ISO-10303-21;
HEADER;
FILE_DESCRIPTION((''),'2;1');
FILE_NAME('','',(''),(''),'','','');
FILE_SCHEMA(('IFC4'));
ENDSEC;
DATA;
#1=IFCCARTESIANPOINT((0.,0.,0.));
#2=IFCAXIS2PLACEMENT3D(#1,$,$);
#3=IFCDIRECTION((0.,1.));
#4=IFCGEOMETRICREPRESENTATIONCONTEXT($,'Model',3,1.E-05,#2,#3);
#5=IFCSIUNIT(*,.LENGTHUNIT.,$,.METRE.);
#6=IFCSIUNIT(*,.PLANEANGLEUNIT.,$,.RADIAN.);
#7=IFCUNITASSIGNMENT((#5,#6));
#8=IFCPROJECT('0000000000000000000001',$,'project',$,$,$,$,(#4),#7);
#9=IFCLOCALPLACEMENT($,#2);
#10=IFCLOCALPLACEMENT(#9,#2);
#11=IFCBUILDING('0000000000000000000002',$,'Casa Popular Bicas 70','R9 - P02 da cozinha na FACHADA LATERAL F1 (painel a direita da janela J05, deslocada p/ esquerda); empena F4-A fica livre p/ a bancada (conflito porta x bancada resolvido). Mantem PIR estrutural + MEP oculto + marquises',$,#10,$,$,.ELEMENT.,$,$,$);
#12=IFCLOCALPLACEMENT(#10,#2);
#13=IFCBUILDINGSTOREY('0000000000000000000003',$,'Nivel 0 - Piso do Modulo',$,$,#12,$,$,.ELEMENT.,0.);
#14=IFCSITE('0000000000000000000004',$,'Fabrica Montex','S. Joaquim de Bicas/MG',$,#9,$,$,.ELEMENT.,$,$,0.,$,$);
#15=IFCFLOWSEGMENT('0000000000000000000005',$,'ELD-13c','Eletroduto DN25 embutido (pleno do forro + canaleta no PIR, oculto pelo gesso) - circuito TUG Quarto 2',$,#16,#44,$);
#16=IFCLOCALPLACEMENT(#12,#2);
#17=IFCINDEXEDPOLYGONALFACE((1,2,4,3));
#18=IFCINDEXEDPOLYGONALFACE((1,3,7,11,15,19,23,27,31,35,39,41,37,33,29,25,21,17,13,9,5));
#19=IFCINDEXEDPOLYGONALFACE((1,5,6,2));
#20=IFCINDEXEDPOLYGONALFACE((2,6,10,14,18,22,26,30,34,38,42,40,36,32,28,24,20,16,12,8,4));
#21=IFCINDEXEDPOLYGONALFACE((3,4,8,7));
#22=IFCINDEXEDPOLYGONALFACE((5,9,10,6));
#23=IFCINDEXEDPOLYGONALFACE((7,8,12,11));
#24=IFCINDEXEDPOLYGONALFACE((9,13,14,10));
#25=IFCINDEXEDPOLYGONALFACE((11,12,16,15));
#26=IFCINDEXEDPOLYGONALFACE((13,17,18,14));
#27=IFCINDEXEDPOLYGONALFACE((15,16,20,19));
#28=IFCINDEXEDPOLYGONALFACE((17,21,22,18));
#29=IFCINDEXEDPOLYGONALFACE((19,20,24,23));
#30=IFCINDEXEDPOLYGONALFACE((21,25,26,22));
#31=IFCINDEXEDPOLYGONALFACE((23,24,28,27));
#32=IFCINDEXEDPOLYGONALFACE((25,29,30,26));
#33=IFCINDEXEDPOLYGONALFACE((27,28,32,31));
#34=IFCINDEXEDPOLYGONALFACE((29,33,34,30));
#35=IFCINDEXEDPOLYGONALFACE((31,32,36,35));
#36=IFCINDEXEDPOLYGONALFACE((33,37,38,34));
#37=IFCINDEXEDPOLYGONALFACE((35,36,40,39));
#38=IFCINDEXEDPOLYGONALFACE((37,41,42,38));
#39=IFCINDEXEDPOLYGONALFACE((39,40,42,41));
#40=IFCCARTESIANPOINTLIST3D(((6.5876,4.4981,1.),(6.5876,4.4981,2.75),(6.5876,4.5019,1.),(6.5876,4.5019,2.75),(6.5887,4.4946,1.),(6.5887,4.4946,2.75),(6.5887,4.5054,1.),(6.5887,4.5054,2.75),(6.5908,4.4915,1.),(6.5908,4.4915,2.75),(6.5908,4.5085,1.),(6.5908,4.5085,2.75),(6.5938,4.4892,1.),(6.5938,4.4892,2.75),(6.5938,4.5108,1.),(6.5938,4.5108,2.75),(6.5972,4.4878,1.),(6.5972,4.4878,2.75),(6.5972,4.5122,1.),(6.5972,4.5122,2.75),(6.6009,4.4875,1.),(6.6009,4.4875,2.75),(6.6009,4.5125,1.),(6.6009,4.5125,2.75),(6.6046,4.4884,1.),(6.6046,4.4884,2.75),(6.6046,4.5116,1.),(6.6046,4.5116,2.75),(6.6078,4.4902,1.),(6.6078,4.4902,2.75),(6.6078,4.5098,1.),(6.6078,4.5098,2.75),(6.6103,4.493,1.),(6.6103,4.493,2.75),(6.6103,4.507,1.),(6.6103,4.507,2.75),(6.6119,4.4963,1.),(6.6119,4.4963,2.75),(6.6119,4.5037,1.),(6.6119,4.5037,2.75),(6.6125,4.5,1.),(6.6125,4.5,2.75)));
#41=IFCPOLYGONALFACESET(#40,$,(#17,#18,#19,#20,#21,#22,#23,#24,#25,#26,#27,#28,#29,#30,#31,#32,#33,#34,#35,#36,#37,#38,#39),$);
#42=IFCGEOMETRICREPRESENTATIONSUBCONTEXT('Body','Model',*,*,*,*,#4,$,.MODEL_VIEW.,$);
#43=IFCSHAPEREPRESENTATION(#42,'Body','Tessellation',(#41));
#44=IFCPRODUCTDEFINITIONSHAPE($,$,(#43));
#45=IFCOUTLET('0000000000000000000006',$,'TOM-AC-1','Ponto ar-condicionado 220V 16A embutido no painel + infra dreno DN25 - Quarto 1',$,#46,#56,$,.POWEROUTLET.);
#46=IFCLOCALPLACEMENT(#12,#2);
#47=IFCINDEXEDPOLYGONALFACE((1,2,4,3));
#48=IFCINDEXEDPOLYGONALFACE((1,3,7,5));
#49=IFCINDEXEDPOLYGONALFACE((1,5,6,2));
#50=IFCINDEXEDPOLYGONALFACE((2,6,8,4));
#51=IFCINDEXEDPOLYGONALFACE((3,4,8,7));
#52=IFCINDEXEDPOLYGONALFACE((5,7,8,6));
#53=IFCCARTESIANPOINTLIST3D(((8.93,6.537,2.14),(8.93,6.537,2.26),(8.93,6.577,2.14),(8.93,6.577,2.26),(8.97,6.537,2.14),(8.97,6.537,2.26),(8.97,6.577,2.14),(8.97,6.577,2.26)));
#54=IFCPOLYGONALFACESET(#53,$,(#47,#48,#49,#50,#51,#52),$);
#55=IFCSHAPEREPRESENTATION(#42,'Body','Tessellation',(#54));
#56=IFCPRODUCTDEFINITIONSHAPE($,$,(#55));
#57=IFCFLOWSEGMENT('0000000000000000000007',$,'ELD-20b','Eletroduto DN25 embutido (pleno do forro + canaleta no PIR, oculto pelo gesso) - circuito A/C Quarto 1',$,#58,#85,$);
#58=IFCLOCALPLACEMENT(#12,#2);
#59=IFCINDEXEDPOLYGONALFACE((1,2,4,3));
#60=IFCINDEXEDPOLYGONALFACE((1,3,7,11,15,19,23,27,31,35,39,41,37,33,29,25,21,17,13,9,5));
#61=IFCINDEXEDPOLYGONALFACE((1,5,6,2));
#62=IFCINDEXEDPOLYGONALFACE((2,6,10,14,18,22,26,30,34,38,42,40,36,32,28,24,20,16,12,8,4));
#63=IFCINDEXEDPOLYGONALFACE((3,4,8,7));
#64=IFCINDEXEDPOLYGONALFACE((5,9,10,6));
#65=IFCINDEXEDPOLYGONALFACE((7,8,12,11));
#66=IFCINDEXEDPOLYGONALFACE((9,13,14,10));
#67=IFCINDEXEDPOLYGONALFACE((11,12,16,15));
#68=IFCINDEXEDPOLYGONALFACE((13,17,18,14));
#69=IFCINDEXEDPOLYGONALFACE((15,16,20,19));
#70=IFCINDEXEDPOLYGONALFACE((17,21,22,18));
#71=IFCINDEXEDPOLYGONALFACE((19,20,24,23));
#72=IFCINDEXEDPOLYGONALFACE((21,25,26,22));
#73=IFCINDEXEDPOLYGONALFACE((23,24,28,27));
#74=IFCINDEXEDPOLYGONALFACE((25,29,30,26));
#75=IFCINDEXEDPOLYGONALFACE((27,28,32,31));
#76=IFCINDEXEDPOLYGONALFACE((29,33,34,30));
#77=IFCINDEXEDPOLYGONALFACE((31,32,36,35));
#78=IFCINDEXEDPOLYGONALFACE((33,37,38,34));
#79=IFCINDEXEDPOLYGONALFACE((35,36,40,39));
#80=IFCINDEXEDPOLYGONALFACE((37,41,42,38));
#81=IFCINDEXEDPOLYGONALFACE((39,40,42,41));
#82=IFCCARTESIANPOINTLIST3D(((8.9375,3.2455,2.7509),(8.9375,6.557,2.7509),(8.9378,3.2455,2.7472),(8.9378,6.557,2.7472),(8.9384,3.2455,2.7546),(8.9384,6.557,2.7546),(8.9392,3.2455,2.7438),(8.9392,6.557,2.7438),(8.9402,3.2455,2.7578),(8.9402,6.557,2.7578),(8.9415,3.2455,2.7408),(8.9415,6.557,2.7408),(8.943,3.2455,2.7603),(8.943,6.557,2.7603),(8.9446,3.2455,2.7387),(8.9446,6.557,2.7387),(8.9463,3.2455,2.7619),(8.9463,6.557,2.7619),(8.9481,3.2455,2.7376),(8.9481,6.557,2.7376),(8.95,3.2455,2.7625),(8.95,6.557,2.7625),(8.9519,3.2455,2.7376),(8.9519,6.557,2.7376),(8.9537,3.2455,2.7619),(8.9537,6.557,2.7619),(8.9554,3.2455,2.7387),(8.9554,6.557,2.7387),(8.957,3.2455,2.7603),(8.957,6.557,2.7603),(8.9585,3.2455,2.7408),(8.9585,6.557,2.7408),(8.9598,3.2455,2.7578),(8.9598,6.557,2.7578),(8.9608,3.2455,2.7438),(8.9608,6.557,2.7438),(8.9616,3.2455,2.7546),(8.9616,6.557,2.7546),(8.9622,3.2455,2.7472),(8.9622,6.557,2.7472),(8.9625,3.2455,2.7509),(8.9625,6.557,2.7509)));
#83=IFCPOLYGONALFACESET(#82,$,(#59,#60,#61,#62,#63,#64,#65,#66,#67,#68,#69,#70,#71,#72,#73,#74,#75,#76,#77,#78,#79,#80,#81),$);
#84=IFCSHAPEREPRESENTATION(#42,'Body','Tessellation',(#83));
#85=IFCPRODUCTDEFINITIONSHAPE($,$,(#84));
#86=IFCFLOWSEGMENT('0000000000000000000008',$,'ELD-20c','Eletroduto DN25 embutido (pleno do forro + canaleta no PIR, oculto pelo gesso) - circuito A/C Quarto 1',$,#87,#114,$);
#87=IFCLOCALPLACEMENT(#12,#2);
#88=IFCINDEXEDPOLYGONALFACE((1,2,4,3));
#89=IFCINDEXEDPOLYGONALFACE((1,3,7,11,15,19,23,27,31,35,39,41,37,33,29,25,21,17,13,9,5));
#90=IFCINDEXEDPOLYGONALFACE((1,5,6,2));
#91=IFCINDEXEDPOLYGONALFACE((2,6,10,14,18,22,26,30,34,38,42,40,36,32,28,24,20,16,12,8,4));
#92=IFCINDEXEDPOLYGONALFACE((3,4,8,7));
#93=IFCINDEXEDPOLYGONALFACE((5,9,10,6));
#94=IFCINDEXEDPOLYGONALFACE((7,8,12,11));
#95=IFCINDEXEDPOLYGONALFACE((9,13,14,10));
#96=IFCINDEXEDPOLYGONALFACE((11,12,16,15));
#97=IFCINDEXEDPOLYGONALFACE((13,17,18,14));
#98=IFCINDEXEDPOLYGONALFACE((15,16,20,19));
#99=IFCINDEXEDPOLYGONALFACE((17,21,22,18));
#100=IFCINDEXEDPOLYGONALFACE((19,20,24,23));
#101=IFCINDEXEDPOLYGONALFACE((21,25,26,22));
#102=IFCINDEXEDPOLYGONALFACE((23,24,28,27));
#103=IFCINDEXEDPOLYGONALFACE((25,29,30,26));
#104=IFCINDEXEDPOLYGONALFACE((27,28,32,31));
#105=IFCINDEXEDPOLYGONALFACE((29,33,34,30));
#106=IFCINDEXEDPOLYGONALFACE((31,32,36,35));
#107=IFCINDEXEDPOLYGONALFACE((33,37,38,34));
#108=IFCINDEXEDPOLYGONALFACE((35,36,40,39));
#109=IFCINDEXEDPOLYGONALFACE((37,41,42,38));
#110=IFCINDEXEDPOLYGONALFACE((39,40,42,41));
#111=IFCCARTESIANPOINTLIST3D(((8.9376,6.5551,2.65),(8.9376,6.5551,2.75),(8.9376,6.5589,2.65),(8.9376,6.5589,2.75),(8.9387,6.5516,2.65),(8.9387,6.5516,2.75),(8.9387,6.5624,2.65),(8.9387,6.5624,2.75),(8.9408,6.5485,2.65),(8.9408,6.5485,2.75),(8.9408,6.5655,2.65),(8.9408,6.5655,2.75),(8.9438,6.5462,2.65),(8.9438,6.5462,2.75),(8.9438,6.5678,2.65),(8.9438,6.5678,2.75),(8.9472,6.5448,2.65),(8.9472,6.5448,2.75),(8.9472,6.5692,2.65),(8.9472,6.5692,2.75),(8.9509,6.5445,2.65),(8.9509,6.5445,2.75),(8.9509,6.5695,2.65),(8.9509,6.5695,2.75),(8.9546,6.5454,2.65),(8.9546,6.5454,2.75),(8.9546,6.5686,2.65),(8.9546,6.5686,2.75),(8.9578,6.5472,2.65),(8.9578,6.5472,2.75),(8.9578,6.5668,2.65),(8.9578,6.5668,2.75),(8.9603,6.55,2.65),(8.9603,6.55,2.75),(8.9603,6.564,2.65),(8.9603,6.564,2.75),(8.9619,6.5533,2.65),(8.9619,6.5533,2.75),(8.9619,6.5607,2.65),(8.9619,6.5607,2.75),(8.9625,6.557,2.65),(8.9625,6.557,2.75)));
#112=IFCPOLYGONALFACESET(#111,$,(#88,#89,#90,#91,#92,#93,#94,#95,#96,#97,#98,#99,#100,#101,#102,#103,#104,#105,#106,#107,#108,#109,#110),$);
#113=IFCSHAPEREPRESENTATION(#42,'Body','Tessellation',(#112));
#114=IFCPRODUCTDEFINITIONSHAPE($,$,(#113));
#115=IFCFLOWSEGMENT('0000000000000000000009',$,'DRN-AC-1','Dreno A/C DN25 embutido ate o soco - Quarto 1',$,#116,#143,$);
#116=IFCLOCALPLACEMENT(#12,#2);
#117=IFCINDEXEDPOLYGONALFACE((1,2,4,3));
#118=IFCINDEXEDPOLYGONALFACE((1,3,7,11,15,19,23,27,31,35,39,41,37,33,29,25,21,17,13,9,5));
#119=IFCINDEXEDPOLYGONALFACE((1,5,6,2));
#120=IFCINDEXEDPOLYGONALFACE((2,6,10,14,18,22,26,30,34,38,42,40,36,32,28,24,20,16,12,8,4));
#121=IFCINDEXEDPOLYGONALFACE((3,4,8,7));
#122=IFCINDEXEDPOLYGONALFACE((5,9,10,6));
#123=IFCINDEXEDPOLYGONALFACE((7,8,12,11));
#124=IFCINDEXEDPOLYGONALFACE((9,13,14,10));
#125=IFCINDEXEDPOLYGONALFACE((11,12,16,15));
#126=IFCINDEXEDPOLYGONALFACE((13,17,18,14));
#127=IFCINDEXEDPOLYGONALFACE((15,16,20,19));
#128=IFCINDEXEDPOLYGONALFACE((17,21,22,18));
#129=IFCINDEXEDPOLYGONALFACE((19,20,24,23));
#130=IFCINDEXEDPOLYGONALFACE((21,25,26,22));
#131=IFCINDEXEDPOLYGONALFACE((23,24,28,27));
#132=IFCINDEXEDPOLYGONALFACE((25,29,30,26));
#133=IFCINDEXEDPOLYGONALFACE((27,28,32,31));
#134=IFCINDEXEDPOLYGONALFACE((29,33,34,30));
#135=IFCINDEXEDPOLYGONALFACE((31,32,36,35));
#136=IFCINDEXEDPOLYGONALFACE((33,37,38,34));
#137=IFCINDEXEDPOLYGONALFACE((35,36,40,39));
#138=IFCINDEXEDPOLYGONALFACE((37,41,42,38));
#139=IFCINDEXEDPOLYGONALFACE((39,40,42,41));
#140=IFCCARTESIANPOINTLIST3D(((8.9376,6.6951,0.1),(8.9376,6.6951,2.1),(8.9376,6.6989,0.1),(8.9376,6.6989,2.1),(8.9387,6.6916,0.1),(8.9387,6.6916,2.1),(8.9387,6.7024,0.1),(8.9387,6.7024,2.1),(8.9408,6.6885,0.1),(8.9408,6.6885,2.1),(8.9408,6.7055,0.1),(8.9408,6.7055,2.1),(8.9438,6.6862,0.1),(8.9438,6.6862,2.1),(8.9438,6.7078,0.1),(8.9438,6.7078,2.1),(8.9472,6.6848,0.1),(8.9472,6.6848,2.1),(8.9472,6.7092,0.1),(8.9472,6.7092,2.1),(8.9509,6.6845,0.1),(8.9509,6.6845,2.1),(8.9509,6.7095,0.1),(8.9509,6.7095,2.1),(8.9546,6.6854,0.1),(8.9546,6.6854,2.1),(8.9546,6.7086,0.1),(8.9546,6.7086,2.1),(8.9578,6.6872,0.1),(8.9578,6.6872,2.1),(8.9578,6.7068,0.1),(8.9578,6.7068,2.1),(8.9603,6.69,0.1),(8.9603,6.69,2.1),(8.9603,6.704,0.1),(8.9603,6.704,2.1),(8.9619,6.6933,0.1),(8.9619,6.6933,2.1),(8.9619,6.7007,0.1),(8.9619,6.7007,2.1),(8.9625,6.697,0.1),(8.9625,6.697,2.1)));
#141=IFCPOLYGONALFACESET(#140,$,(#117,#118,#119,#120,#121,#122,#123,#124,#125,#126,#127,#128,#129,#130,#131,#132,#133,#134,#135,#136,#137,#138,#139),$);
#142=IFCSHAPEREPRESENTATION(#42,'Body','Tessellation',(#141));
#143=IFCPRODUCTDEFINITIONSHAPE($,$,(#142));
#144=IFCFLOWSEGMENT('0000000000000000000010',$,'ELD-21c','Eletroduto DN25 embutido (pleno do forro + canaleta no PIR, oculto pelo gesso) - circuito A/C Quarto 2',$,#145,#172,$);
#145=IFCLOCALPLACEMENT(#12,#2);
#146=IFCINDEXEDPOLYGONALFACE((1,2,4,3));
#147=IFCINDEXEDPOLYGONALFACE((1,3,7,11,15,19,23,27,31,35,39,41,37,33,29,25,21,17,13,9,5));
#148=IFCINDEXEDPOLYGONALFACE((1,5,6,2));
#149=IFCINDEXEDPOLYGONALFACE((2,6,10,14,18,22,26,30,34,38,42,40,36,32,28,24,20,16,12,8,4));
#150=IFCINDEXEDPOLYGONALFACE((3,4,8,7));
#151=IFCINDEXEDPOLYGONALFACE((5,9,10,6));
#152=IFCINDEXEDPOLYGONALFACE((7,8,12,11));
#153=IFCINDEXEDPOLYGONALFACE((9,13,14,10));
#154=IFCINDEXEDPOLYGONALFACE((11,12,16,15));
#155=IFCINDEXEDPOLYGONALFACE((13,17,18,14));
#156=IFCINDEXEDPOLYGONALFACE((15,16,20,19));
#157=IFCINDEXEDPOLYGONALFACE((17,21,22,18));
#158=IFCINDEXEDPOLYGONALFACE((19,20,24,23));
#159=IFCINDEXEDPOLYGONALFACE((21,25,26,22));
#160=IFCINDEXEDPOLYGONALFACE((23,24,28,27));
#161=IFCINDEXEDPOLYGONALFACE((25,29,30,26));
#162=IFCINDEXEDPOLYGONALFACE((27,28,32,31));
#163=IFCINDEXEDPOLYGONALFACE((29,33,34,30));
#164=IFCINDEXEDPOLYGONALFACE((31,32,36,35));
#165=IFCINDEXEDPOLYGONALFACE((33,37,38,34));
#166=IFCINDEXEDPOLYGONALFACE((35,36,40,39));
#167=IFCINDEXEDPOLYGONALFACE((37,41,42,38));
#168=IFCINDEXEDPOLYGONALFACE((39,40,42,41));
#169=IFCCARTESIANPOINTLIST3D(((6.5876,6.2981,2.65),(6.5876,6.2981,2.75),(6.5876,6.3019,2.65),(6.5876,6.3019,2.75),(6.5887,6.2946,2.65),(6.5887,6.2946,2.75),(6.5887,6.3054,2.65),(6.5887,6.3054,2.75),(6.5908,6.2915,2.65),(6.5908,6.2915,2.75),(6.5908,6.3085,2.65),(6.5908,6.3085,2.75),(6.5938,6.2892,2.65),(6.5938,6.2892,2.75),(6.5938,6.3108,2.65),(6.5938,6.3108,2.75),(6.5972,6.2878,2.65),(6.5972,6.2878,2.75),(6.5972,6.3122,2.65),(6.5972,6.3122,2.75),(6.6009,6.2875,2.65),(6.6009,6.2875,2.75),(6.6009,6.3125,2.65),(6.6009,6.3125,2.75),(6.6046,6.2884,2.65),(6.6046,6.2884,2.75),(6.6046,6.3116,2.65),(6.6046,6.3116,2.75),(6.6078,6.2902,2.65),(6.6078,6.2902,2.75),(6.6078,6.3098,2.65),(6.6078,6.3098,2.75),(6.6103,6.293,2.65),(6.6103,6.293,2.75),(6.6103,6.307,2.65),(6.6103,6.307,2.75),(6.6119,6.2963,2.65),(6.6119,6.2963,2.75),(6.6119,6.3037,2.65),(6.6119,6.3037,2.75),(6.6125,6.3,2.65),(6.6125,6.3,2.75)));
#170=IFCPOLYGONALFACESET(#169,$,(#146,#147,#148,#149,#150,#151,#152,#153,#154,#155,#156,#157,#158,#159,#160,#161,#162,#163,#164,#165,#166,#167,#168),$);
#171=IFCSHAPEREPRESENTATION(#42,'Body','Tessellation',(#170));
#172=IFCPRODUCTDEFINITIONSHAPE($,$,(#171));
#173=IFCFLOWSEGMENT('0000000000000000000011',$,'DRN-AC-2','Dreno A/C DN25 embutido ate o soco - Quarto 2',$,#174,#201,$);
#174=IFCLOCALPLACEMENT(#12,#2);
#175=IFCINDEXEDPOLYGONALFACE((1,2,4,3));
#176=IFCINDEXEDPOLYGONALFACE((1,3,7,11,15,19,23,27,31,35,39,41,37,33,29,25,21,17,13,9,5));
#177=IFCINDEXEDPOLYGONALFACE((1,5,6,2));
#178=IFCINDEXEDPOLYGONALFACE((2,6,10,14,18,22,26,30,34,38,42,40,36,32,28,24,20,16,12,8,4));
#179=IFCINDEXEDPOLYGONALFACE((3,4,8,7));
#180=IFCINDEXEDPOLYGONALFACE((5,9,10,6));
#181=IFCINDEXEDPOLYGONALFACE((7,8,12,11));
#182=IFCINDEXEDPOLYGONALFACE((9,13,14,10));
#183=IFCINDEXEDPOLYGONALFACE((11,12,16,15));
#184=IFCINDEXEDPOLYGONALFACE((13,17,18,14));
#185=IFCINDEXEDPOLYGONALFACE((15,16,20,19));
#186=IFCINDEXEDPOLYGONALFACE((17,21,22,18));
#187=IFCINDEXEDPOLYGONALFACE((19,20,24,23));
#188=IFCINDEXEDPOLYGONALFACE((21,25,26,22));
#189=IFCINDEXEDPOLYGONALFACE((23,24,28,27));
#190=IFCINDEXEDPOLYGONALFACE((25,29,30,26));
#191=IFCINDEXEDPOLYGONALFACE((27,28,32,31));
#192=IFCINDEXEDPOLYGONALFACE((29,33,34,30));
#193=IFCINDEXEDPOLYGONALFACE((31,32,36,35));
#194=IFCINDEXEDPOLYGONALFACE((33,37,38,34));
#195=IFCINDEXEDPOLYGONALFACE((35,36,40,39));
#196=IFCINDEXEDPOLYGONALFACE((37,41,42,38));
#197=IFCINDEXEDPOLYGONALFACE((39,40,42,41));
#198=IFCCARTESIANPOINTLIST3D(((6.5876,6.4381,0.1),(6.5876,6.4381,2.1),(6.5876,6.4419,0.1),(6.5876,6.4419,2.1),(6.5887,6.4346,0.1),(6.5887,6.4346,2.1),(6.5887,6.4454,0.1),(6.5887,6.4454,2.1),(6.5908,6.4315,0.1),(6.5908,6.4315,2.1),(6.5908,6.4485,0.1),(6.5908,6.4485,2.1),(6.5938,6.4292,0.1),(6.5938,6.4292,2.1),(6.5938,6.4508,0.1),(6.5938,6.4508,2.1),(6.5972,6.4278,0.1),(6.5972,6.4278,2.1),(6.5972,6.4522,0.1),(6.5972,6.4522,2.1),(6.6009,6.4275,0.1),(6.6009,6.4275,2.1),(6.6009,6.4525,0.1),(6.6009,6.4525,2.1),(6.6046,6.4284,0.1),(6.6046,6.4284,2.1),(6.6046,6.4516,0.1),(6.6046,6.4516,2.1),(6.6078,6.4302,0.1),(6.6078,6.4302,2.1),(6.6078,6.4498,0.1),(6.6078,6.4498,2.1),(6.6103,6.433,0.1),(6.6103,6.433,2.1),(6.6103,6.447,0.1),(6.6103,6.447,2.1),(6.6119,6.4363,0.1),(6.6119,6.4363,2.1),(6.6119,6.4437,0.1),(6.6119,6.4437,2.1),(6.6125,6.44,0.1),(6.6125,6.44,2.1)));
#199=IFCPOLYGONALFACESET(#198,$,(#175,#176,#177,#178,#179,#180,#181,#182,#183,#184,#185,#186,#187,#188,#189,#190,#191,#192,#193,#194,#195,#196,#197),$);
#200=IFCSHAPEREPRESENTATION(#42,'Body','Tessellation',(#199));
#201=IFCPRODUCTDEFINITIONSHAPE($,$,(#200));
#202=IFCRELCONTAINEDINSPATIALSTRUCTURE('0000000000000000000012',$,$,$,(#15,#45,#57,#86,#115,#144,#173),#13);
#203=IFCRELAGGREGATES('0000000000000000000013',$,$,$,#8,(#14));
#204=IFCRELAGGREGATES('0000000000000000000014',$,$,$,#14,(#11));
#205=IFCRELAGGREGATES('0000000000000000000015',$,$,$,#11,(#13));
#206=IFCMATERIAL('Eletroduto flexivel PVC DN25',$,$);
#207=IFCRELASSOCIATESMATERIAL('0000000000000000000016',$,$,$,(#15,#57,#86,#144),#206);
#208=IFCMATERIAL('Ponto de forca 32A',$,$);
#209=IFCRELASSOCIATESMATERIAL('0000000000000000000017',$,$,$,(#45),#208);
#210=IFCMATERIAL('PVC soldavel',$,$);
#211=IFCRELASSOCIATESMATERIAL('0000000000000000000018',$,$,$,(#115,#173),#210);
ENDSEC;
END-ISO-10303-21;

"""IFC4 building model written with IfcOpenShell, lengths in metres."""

from ifc_helpers import new_model, si_unit, direction, frame, frame_2d, origin, origin_2d, place, context, subcontext, project, spatial, rectangle, circle, extrude, material, element, save


model = new_model("IFC4")

# Units and contexts
model_context = context("Model", 3, precision=1e-05, world=origin(), true_north=direction((0.0, 1.0)))
body_context = subcontext(model_context, "Body", "Model", "MODEL_VIEW")
ifc_project = project(units=[si_unit("LENGTHUNIT", "METRE"), si_unit("PLANEANGLEUNIT", "RADIAN")], contexts=[model_context])

# Site, building, storey
site_placement = place(None, origin())
site = spatial("IfcSite", under=ifc_project, at=site_placement, Name="Fabrica Montex", Description="S. Joaquim de Bicas/MG", CompositionType="ELEMENT", RefElevation=0.0)
building_placement = place(site_placement, origin())
building = spatial("IfcBuilding", under=site, at=building_placement, Name="Casa Popular Bicas 70", Description="R9 - P02 da cozinha na FACHADA LATERAL F1 (painel a direita da janela J05, deslocada p/ esquerda); empena F4-A fica livre p/ a bancada (conflito porta x bancada resolvido). Mantem PIR estrutural + MEP oculto + marquises", CompositionType="ELEMENT")
storey_placement = place(building_placement, origin())
storey = spatial("IfcBuildingStorey", under=building, at=storey_placement, Name="Nivel 0 - Piso do Modulo", CompositionType="ELEMENT", Elevation=0.0)

# Shared definitions
ifc_material_1 = material(Name="Eletroduto flexivel PVC DN25")

# Flow segment
for number, where, z_axis, x_axis, name in (
    (1, (6.6, 4.5, 2.75), (0.0, 0.0, -1.0), (1.0, 0.0, 0.0), "ELD-13c"),
):
    element("IfcFlowSegment", number, at=place(storey_placement, frame(where, z_axis=z_axis, x_axis=x_axis)), inside=storey, material=ifc_material_1, Name=name, Description="Eletroduto DN25 embutido (pleno do forro + canaleta no PIR, oculto pelo gesso) - circuito TUG Quarto 2", context=body_context, shape_type="SweptSolid", body=[
        extrude(circle(Radius=0.0125, at=origin_2d()), origin(), (0.0, 0.0, 1.0), 1.75),
    ])

# Outlet
ifc_material_2 = material(Name="Ponto de forca 32A")
outlet_1_placement = place(storey_placement, frame((8.93, 6.537, 2.14)))
element("IfcOutlet", 2, at=outlet_1_placement, inside=storey, material=ifc_material_2, Name="TOM-AC-1", Description="Ponto ar-condicionado 220V 16A embutido no painel + infra dreno DN25 - Quarto 1", PredefinedType="POWEROUTLET", context=body_context, shape_type="SweptSolid", body=[
    extrude(rectangle(XDim=0.04, YDim=0.04, at=frame_2d((0.02, 0.02))), origin(), (0.0, 0.0, 1.0), 0.12),
])

# Flow segments
flow_segment_1_placement = place(storey_placement, frame((8.95, 3.2455, 2.75), z_axis=(0.0, 1.0, 0.0), x_axis=(0.0, 0.0, 1.0)))
element("IfcFlowSegment", 3, at=flow_segment_1_placement, inside=storey, material=ifc_material_1, Name="ELD-20b", Description="Eletroduto DN25 embutido (pleno do forro + canaleta no PIR, oculto pelo gesso) - circuito A/C Quarto 1", context=body_context, shape_type="SweptSolid", body=[
    extrude(circle(Radius=0.0125, at=origin_2d()), origin(), (0.0, 0.0, 1.0), 3.3115),
])
flow_segment_2_placement = place(storey_placement, frame((8.95, 6.557, 2.75), z_axis=(0.0, 0.0, -1.0), x_axis=(1.0, 0.0, 0.0)))
element("IfcFlowSegment", 4, at=flow_segment_2_placement, inside=storey, material=ifc_material_1, Name="ELD-20c", Description="Eletroduto DN25 embutido (pleno do forro + canaleta no PIR, oculto pelo gesso) - circuito A/C Quarto 1", context=body_context, shape_type="SweptSolid", body=[
    extrude(circle(Radius=0.0125, at=origin_2d()), origin(), (0.0, 0.0, 1.0), 0.1),
])
ifc_material_3 = material(Name="PVC soldavel")
flow_segment_3_placement = place(storey_placement, frame((8.95, 6.697, 2.1), z_axis=(0.0, 0.0, -1.0), x_axis=(1.0, 0.0, 0.0)))
element("IfcFlowSegment", 5, at=flow_segment_3_placement, inside=storey, material=ifc_material_3, Name="DRN-AC-1", Description="Dreno A/C DN25 embutido ate o soco - Quarto 1", context=body_context, shape_type="SweptSolid", body=[
    extrude(circle(Radius=0.0125, at=origin_2d()), origin(), (0.0, 0.0, 1.0), 2.0),
])
flow_segment_4_placement = place(storey_placement, frame((6.6, 6.3, 2.75), z_axis=(0.0, 0.0, -1.0), x_axis=(1.0, 0.0, 0.0)))
element("IfcFlowSegment", 6, at=flow_segment_4_placement, inside=storey, material=ifc_material_1, Name="ELD-21c", Description="Eletroduto DN25 embutido (pleno do forro + canaleta no PIR, oculto pelo gesso) - circuito A/C Quarto 2", context=body_context, shape_type="SweptSolid", body=[
    extrude(circle(Radius=0.0125, at=origin_2d()), origin(), (0.0, 0.0, 1.0), 0.1),
])
flow_segment_5_placement = place(storey_placement, frame((6.6, 6.44, 2.1), z_axis=(0.0, 0.0, -1.0), x_axis=(1.0, 0.0, 0.0)))
element("IfcFlowSegment", 7, at=flow_segment_5_placement, inside=storey, material=ifc_material_3, Name="DRN-AC-2", Description="Dreno A/C DN25 embutido ate o soco - Quarto 2", context=body_context, shape_type="SweptSolid", body=[
    extrude(circle(Radius=0.0125, at=origin_2d()), origin(), (0.0, 0.0, 1.0), 2.0),
])

save(model, "model.ifc")
